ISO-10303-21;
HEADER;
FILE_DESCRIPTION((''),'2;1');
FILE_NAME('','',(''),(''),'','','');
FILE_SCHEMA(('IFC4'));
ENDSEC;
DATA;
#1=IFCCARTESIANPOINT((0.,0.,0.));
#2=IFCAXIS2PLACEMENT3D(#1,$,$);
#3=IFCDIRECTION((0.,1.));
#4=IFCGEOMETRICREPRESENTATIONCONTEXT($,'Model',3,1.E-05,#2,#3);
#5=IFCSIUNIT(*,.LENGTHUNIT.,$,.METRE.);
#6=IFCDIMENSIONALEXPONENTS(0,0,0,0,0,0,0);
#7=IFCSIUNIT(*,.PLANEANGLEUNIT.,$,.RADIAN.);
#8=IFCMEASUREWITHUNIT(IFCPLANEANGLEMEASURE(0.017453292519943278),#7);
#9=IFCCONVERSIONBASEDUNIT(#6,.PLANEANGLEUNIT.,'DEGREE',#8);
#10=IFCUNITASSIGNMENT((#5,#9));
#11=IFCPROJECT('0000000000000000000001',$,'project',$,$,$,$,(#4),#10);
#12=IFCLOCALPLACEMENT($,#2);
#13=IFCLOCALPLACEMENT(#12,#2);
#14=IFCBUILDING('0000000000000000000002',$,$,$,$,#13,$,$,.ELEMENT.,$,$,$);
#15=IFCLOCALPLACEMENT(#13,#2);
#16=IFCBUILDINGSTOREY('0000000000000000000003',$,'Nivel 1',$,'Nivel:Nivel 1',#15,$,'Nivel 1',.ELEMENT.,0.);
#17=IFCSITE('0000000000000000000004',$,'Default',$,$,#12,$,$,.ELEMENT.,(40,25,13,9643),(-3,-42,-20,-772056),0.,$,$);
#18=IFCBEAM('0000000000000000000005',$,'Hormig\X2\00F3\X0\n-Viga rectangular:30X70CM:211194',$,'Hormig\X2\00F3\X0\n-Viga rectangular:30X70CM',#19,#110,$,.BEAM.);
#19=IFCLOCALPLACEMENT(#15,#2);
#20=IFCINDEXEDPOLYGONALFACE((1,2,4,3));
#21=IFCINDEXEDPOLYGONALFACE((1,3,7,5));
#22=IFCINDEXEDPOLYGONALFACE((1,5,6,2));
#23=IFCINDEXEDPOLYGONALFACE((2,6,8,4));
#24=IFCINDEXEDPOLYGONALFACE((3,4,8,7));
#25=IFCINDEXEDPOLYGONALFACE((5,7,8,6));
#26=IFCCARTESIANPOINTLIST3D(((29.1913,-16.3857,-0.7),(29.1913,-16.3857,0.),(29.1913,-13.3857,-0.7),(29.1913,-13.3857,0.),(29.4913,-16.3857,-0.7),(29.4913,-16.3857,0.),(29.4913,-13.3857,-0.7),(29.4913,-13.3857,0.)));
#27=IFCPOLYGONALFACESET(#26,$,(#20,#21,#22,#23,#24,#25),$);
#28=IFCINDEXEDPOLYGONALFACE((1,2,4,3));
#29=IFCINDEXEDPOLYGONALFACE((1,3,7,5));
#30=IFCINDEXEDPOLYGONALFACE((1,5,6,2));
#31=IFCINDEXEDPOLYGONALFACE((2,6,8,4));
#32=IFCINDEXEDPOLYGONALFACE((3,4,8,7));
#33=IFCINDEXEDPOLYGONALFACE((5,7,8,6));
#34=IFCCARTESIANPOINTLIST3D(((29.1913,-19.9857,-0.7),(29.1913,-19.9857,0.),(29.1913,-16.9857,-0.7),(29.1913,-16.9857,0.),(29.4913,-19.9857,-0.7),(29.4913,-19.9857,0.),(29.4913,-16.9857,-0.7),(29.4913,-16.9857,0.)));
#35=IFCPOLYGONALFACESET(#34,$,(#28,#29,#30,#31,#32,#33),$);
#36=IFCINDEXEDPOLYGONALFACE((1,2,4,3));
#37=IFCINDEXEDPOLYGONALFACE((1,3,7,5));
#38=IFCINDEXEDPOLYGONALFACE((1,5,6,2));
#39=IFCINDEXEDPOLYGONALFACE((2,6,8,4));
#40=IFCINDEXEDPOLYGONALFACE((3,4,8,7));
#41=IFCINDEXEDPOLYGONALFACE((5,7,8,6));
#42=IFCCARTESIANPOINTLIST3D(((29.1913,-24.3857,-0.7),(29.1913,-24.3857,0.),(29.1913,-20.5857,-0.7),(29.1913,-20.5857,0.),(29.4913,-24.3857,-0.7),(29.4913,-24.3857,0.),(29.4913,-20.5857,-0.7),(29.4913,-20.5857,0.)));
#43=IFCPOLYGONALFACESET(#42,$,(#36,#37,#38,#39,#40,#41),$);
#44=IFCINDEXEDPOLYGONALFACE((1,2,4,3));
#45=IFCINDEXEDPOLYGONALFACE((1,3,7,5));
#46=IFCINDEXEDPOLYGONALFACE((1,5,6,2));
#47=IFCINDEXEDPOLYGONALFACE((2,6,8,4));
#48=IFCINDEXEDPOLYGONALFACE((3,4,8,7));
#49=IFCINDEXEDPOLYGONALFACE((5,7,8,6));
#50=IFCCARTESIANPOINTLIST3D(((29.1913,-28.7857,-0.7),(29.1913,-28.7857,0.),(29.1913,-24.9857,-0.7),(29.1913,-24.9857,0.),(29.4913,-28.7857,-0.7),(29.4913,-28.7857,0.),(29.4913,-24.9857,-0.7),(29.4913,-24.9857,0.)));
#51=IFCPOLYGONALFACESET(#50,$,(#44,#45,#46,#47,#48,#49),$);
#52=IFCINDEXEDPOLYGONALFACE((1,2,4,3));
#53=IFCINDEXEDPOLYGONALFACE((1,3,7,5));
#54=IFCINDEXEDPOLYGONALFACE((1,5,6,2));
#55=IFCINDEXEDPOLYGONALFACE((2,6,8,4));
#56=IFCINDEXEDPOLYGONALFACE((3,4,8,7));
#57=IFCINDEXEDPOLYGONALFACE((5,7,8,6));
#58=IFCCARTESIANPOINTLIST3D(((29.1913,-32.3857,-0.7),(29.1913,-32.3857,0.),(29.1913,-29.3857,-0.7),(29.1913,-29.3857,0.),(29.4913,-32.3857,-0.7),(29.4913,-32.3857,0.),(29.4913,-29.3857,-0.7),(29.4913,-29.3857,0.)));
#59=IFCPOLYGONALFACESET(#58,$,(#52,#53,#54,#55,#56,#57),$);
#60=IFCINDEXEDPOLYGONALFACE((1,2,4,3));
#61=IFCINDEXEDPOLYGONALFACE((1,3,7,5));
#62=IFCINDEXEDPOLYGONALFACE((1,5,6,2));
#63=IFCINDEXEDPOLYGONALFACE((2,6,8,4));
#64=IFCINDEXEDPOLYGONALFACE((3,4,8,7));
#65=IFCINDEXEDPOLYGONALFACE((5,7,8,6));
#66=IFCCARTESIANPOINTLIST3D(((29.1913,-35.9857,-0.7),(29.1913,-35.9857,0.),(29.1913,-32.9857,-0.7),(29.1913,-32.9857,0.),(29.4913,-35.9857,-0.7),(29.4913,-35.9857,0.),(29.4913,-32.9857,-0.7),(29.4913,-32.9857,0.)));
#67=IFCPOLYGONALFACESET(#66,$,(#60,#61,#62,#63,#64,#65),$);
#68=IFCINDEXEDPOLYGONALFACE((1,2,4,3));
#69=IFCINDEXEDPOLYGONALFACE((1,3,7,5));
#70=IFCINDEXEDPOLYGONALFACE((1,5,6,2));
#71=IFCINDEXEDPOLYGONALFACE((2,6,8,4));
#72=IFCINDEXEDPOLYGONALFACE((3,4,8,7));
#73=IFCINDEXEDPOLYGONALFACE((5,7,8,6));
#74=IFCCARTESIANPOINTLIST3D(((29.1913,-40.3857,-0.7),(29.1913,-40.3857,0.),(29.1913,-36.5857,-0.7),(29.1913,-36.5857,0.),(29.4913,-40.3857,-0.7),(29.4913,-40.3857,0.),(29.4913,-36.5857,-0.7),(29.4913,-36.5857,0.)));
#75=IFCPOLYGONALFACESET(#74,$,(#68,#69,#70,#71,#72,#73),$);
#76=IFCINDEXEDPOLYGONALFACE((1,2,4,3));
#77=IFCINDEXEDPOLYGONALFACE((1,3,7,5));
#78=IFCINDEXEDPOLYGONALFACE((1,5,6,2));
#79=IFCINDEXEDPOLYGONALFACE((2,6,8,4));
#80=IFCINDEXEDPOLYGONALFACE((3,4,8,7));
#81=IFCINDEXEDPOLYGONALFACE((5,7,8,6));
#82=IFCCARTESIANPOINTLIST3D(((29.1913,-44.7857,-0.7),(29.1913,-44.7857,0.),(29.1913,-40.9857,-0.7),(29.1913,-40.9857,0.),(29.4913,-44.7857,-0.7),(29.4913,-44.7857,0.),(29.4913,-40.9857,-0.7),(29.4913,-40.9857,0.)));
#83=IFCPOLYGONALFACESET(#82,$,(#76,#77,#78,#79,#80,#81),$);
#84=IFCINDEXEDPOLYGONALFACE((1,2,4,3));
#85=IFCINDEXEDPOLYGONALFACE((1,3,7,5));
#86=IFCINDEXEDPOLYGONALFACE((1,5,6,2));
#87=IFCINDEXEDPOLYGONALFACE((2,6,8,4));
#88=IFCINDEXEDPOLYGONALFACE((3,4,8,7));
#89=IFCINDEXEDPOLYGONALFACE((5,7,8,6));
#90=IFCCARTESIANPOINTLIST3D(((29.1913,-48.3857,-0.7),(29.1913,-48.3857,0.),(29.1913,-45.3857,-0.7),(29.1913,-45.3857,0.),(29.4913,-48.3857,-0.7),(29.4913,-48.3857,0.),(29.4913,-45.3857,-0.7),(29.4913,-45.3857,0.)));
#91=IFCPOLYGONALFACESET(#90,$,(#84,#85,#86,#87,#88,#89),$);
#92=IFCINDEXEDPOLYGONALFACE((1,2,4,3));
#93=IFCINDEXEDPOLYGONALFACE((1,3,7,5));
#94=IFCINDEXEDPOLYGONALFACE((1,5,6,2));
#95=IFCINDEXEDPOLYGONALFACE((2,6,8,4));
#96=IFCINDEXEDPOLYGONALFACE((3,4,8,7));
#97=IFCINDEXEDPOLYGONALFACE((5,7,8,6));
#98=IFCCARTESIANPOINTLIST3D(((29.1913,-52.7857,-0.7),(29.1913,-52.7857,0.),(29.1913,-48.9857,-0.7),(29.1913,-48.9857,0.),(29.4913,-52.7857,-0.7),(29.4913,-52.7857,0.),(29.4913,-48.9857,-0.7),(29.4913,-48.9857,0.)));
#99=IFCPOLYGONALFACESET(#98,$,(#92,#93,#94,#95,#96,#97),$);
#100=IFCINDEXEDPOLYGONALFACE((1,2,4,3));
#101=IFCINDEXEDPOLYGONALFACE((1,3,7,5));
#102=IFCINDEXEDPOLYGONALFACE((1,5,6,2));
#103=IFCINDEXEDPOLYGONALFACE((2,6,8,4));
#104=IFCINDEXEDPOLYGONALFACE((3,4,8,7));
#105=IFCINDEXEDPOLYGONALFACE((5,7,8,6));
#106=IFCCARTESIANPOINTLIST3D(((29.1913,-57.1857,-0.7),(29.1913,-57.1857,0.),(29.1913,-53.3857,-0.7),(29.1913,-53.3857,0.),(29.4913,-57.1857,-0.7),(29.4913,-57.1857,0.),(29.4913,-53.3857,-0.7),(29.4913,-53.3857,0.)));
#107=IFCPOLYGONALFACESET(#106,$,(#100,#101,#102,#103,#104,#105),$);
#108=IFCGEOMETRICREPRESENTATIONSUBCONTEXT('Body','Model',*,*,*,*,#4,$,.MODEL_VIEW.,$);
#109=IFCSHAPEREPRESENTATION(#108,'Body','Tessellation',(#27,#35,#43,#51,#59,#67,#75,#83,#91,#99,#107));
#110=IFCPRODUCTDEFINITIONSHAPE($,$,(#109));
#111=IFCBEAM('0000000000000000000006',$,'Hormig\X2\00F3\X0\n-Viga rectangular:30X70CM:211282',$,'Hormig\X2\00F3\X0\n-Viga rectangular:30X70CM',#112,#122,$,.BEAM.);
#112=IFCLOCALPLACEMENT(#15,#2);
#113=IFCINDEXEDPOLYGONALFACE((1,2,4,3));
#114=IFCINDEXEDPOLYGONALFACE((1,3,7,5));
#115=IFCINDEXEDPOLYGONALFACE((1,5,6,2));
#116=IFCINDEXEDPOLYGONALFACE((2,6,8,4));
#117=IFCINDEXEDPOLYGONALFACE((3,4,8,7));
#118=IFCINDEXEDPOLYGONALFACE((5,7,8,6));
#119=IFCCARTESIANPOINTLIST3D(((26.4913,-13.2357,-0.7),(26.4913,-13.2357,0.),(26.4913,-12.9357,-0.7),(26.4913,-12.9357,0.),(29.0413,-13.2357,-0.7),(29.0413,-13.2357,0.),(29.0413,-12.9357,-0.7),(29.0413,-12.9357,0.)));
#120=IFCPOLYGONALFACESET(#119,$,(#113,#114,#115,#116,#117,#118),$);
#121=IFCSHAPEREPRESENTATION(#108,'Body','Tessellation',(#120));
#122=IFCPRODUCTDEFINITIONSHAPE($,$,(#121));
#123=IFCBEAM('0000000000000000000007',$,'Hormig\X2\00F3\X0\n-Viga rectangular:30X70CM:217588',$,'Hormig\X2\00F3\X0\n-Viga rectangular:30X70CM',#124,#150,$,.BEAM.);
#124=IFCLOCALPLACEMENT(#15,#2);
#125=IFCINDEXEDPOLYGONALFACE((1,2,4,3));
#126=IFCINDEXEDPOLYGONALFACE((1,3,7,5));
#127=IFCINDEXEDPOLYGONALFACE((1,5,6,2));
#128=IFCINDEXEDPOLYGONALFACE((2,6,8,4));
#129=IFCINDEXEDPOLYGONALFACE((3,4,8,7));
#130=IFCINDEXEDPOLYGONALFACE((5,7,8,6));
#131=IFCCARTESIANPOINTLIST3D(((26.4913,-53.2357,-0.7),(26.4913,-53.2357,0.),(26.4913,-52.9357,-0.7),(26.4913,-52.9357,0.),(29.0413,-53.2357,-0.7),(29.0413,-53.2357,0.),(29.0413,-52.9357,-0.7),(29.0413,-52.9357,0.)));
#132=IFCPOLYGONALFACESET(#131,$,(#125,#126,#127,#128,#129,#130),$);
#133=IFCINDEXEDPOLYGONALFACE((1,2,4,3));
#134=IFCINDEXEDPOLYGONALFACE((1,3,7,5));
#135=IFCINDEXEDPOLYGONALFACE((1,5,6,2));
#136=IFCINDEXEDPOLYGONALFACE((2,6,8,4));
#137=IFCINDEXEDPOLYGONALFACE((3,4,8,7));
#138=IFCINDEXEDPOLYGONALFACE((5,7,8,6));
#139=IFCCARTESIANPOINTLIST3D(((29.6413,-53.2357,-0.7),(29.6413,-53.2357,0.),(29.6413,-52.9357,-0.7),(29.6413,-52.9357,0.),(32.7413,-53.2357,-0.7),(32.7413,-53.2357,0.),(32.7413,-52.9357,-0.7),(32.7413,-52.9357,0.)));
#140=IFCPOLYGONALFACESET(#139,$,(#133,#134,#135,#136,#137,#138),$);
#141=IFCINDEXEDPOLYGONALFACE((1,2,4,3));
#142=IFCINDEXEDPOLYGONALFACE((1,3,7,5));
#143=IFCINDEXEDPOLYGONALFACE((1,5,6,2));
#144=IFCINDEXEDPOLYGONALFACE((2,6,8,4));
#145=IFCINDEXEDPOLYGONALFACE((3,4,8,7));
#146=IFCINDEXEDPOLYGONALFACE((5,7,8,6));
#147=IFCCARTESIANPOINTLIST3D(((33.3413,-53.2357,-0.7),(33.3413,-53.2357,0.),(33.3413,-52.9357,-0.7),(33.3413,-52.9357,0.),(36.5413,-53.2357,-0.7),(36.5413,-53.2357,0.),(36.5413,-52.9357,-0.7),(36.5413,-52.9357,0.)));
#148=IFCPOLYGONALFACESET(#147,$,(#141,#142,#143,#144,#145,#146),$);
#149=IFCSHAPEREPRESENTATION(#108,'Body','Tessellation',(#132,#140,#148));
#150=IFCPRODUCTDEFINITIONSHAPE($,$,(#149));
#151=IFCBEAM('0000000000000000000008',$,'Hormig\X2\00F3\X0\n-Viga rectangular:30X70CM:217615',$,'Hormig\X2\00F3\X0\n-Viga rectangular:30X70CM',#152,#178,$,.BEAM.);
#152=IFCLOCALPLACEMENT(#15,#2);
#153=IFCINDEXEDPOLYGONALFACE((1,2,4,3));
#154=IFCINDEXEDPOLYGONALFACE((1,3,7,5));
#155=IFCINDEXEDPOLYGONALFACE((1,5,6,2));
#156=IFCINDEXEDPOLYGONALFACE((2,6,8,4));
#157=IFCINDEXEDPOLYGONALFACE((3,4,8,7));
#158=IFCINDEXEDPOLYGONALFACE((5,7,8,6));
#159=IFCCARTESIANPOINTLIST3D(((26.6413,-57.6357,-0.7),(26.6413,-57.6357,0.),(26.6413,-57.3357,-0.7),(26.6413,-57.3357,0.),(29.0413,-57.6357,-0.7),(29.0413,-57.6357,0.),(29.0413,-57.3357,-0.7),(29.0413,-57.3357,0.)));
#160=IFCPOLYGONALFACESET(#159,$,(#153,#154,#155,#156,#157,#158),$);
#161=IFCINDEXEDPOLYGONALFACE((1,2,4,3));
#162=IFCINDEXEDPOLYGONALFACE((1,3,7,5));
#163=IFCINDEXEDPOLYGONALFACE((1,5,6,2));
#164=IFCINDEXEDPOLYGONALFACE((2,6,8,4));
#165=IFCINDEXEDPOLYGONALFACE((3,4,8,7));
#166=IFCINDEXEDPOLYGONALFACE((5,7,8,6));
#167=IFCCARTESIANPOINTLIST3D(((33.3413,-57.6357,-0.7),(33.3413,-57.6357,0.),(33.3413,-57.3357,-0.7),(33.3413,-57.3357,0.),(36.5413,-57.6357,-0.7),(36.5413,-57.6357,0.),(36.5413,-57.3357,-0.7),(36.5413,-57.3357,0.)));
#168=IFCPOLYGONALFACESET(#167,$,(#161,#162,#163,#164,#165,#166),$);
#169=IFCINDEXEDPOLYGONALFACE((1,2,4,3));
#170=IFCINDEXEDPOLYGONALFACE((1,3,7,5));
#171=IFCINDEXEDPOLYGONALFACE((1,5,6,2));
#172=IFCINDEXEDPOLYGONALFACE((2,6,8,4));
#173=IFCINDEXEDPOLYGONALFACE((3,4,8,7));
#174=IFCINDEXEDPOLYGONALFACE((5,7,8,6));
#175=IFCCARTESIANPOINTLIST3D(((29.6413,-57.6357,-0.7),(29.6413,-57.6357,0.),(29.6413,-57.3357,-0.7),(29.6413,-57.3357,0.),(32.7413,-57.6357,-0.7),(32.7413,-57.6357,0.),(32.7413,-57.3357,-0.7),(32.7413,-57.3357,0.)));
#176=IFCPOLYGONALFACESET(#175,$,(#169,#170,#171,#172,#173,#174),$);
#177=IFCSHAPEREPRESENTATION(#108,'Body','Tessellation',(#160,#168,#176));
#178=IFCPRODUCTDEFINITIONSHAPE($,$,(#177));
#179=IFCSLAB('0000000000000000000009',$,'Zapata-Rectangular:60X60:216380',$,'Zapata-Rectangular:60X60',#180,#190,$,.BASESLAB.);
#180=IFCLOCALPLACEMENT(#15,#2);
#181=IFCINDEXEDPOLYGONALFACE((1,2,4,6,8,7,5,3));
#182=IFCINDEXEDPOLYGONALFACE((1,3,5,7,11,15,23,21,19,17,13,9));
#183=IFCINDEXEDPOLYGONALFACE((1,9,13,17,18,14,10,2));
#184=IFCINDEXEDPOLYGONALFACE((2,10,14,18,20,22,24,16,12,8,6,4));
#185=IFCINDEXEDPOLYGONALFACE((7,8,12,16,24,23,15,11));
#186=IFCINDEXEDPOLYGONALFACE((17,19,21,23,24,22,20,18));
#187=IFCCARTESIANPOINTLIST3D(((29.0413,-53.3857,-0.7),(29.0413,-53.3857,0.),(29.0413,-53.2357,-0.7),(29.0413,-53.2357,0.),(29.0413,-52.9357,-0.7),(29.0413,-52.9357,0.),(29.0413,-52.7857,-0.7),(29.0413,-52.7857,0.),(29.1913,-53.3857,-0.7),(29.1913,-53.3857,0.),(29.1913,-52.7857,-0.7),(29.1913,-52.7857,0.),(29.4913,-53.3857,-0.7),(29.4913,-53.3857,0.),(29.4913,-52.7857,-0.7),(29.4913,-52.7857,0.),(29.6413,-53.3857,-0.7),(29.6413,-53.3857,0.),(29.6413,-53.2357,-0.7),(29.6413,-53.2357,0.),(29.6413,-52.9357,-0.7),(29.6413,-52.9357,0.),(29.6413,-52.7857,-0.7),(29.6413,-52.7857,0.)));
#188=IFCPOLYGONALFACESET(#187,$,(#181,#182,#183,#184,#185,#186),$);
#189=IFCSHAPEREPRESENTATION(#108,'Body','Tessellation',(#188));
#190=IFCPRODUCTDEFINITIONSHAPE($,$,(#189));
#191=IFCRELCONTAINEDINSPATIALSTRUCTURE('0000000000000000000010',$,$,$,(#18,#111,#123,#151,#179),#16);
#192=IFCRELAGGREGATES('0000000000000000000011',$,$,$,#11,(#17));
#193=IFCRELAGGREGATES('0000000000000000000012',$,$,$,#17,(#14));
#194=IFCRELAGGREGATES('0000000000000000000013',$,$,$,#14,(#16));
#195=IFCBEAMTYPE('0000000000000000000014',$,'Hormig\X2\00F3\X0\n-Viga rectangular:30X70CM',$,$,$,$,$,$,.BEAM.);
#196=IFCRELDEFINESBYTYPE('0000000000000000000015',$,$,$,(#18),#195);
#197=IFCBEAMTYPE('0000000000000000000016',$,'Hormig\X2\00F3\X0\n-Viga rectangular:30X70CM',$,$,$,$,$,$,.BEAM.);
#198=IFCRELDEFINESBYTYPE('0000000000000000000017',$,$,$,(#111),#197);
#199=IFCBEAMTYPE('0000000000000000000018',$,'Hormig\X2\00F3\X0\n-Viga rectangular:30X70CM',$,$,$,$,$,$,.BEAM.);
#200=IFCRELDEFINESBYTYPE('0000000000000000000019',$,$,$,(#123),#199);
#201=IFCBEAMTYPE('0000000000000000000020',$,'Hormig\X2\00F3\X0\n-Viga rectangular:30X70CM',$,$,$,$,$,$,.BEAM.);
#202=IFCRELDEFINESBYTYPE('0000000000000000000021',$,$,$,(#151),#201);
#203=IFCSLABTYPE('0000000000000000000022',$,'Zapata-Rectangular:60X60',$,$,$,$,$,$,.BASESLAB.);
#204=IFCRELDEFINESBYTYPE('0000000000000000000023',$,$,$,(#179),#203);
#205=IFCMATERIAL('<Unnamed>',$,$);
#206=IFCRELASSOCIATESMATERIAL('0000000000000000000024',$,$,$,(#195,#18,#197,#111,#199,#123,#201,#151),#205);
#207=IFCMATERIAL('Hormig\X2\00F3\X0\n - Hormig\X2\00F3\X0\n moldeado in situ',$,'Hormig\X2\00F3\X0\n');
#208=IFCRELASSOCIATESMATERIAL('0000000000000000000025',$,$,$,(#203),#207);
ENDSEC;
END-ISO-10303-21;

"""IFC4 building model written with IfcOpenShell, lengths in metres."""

from ifc_helpers import new_model, entity, si_unit, converted_unit, direction, frame, origin, place, context, subcontext, project, spatial, indexed_curve, outline, extrude, source, transform, mapped, material, type_object, type_shapes, element, save


model = new_model("IFC4")

# Units and contexts
model_context = context("Model", 3, precision=1e-05, world=origin(), true_north=direction((0.0, 1.0)))
body_context = subcontext(model_context, "Body", "Model", "MODEL_VIEW")
ifc_project = project(units=[si_unit("LENGTHUNIT", "METRE"), converted_unit("PLANEANGLEUNIT", "DEGREE", entity("IfcPlaneAngleMeasure", 0.017453292519943278), si_unit("PLANEANGLEUNIT", "RADIAN"), dimensions=[0, 0, 0, 0, 0, 0, 0])], contexts=[model_context])

# Site, building, storey
site_placement = place(None, origin())
site = spatial("IfcSite", under=ifc_project, at=site_placement, Name="Default", CompositionType="ELEMENT", RefLatitude=(40, 25, 13, 9643), RefLongitude=(-3, -42, -20, -772056), RefElevation=0.0)
building_placement = place(site_placement, origin())
building = spatial("IfcBuilding", under=site, at=building_placement, CompositionType="ELEMENT")
storey_placement = place(building_placement, origin())
storey = spatial("IfcBuildingStorey", under=building, at=storey_placement, Name="Nivel 1", ObjectType="Nivel:Nivel 1", LongName="Nivel 1", CompositionType="ELEMENT", Elevation=0.0)

# Beams
ifc_material_1 = material(Name="<Unnamed>")
beam_type_1 = type_object("IfcBeamType", Name="Hormigón-Viga rectangular:30X70CM", PredefinedType="BEAM", material=ifc_material_1)
shared_shape_1 = source(origin(), body_context, "Body", "SweptSolid", [
    extrude(outline(indexed_curve([(-0.15, -0.35), (0.15, -0.35), (0.15, 0.35), (-0.15, 0.35), (-0.15, -0.35)], self_intersect=False)), frame((29.3413, -13.3857, -0.35), z_axis=(0.0, -1.0, 0.0), x_axis=(-1.0, 0.0, 0.0)), (0.0, 0.0, 1.0), 3.0),
    extrude(outline(indexed_curve([(-0.15, -0.35), (0.15, -0.35), (0.15, 0.35), (-0.15, 0.35), (-0.15, -0.35)], self_intersect=False)), frame((29.3413, -16.9857, -0.35), z_axis=(0.0, -1.0, 0.0), x_axis=(-1.0, 0.0, 0.0)), (0.0, 0.0, 1.0), 3.0),
    extrude(outline(indexed_curve([(-0.15, -0.35), (0.15, -0.35), (0.15, 0.35), (-0.15, 0.35), (-0.15, -0.35)], self_intersect=False)), frame((29.3413, -20.5857, -0.35), z_axis=(0.0, -1.0, 0.0), x_axis=(-1.0, 0.0, 0.0)), (0.0, 0.0, 1.0), 3.8),
    extrude(outline(indexed_curve([(-0.15, -0.35), (0.15, -0.35), (0.15, 0.35), (-0.15, 0.35), (-0.15, -0.35)], self_intersect=False)), frame((29.3413, -24.9857, -0.35), z_axis=(0.0, -1.0, 0.0), x_axis=(-1.0, 0.0, 0.0)), (0.0, 0.0, 1.0), 3.8),
    extrude(outline(indexed_curve([(-0.15, -0.35), (0.15, -0.35), (0.15, 0.35), (-0.15, 0.35), (-0.15, -0.35)], self_intersect=False)), frame((29.3413, -29.3857, -0.35), z_axis=(0.0, -1.0, 0.0), x_axis=(-1.0, 0.0, 0.0)), (0.0, 0.0, 1.0), 3.0),
    extrude(outline(indexed_curve([(-0.15, -0.35), (0.15, -0.35), (0.15, 0.35), (-0.15, 0.35), (-0.15, -0.35)], self_intersect=False)), frame((29.3413, -32.9857, -0.35), z_axis=(0.0, -1.0, 0.0), x_axis=(-1.0, 0.0, 0.0)), (0.0, 0.0, 1.0), 3.0),
    extrude(outline(indexed_curve([(-0.15, -0.35), (0.15, -0.35), (0.15, 0.35), (-0.15, 0.35), (-0.15, -0.35)], self_intersect=False)), frame((29.3413, -36.5857, -0.35), z_axis=(0.0, -1.0, 0.0), x_axis=(-1.0, 0.0, 0.0)), (0.0, 0.0, 1.0), 3.8),
    extrude(outline(indexed_curve([(-0.15, -0.35), (0.15, -0.35), (0.15, 0.35), (-0.15, 0.35), (-0.15, -0.35)], self_intersect=False)), frame((29.3413, -40.9857, -0.35), z_axis=(0.0, -1.0, 0.0), x_axis=(-1.0, 0.0, 0.0)), (0.0, 0.0, 1.0), 3.8),
    extrude(outline(indexed_curve([(-0.15, -0.35), (0.15, -0.35), (0.15, 0.35), (-0.15, 0.35), (-0.15, -0.35)], self_intersect=False)), frame((29.3413, -45.3857, -0.35), z_axis=(0.0, -1.0, 0.0), x_axis=(-1.0, 0.0, 0.0)), (0.0, 0.0, 1.0), 3.0),
    extrude(outline(indexed_curve([(-0.15, -0.35), (0.15, -0.35), (0.15, 0.35), (-0.15, 0.35), (-0.15, -0.35)], self_intersect=False)), frame((29.3413, -48.9857, -0.35), z_axis=(0.0, -1.0, 0.0), x_axis=(-1.0, 0.0, 0.0)), (0.0, 0.0, 1.0), 3.8),
    extrude(outline(indexed_curve([(-0.15, -0.35), (0.15, -0.35), (0.15, 0.35), (-0.15, 0.35), (-0.15, -0.35)], self_intersect=False)), frame((29.3413, -53.3857, -0.35), z_axis=(0.0, -1.0, 0.0), x_axis=(-1.0, 0.0, 0.0)), (0.0, 0.0, 1.0), 3.8),
])
type_shapes(beam_type_1, [shared_shape_1])
beam_1_placement = place(storey_placement, origin())
element("IfcBeam", 1, at=beam_1_placement, inside=storey, type_object=beam_type_1, material=ifc_material_1, Name="Hormigón-Viga rectangular:30X70CM:211194", ObjectType="Hormigón-Viga rectangular:30X70CM", PredefinedType="BEAM", context=body_context, shape_type="MappedRepresentation", body=[
    mapped(shared_shape_1, transform((0.0, 0.0, 0.0), scale=1.0)),
])
beam_type_2 = type_object("IfcBeamType", Name="Hormigón-Viga rectangular:30X70CM", PredefinedType="BEAM", material=ifc_material_1)
shared_shape_2 = source(origin(), body_context, "Body", "SweptSolid", [
    extrude(outline(indexed_curve([(-0.35, -0.15), (0.35, -0.15), (0.35, 0.15), (-0.35, 0.15), (-0.35, -0.15)], self_intersect=False)), frame((29.0413, -13.0857, -0.35), z_axis=(-1.0, 0.0, 0.0), x_axis=(0.0, 0.0, -1.0)), (0.0, 0.0, 1.0), 2.55),
])
type_shapes(beam_type_2, [shared_shape_2])
beam_2_placement = place(storey_placement, origin())
element("IfcBeam", 2, at=beam_2_placement, inside=storey, type_object=beam_type_2, material=ifc_material_1, Name="Hormigón-Viga rectangular:30X70CM:211282", ObjectType="Hormigón-Viga rectangular:30X70CM", PredefinedType="BEAM", context=body_context, shape_type="MappedRepresentation", body=[
    mapped(shared_shape_2, transform((0.0, 0.0, 0.0), scale=1.0)),
])
beam_type_3 = type_object("IfcBeamType", Name="Hormigón-Viga rectangular:30X70CM", PredefinedType="BEAM", material=ifc_material_1)
shared_shape_3 = source(origin(), body_context, "Body", "SweptSolid", [
    extrude(outline(indexed_curve([(-0.35, -0.15), (0.35, -0.15), (0.35, 0.15), (-0.35, 0.15), (-0.35, -0.15)], self_intersect=False)), frame((26.4913, -53.0857, -0.35), z_axis=(1.0, 0.0, 0.0), x_axis=(0.0, 0.0, -1.0)), (0.0, 0.0, 1.0), 2.55),
    extrude(outline(indexed_curve([(-0.35, -0.15), (0.35, -0.15), (0.35, 0.15), (-0.35, 0.15), (-0.35, -0.15)], self_intersect=False)), frame((29.6413, -53.0857, -0.35), z_axis=(1.0, 0.0, 0.0), x_axis=(0.0, 0.0, -1.0)), (0.0, 0.0, 1.0), 3.1),
    extrude(outline(indexed_curve([(-0.35, -0.15), (0.35, -0.15), (0.35, 0.15), (-0.35, 0.15), (-0.35, -0.15)], self_intersect=False)), frame((33.3413, -53.0857, -0.35), z_axis=(1.0, 0.0, 0.0), x_axis=(0.0, 0.0, -1.0)), (0.0, 0.0, 1.0), 3.2),
])
type_shapes(beam_type_3, [shared_shape_3])
beam_3_placement = place(storey_placement, origin())
element("IfcBeam", 3, at=beam_3_placement, inside=storey, type_object=beam_type_3, material=ifc_material_1, Name="Hormigón-Viga rectangular:30X70CM:217588", ObjectType="Hormigón-Viga rectangular:30X70CM", PredefinedType="BEAM", context=body_context, shape_type="MappedRepresentation", body=[
    mapped(shared_shape_3, transform((0.0, 0.0, 0.0), scale=1.0)),
])
beam_type_4 = type_object("IfcBeamType", Name="Hormigón-Viga rectangular:30X70CM", PredefinedType="BEAM", material=ifc_material_1)
shared_shape_4 = source(origin(), body_context, "Body", "SweptSolid", [
    extrude(outline(indexed_curve([(-0.35, -0.15), (0.35, -0.15), (0.35, 0.15), (-0.35, 0.15), (-0.35, -0.15)], self_intersect=False)), frame((26.6413, -57.4857, -0.35), z_axis=(1.0, 0.0, 0.0), x_axis=(0.0, 0.0, -1.0)), (0.0, 0.0, 1.0), 2.4),
    extrude(outline(indexed_curve([(-0.35, -0.15), (0.35, -0.15), (0.35, 0.15), (-0.35, 0.15), (-0.35, -0.15)], self_intersect=False)), frame((33.3413, -57.4857, -0.35), z_axis=(1.0, 0.0, 0.0), x_axis=(0.0, 0.0, -1.0)), (0.0, 0.0, 1.0), 3.2),
    extrude(outline(indexed_curve([(-0.35, -0.15), (0.35, -0.15), (0.35, 0.15), (-0.35, 0.15), (-0.35, -0.15)], self_intersect=False)), frame((29.6413, -57.4857, -0.35), z_axis=(1.0, 0.0, 0.0), x_axis=(0.0, 0.0, -1.0)), (0.0, 0.0, 1.0), 3.1),
])
type_shapes(beam_type_4, [shared_shape_4])
beam_4_placement = place(storey_placement, origin())
element("IfcBeam", 4, at=beam_4_placement, inside=storey, type_object=beam_type_4, material=ifc_material_1, Name="Hormigón-Viga rectangular:30X70CM:217615", ObjectType="Hormigón-Viga rectangular:30X70CM", PredefinedType="BEAM", context=body_context, shape_type="MappedRepresentation", body=[
    mapped(shared_shape_4, transform((0.0, 0.0, 0.0), scale=1.0)),
])

# Slab
ifc_material_2 = material(Name="Hormigón - Hormigón moldeado in situ", Category="Hormigón")
slab_type_1 = type_object("IfcSlabType", Name="Zapata-Rectangular:60X60", PredefinedType="BASESLAB", material=ifc_material_2)
slab_1_placement = place(storey_placement, origin())
element("IfcSlab", 5, at=slab_1_placement, inside=storey, type_object=slab_type_1, Name="Zapata-Rectangular:60X60:216380", ObjectType="Zapata-Rectangular:60X60", PredefinedType="BASESLAB", context=body_context, shape_type="SweptSolid", body=[
    extrude(outline(indexed_curve([(-0.3, -0.3), (-0.15, -0.3), (0.15, -0.3), (0.3, -0.3), (0.3, -0.15), (0.3, 0.15), (0.3, 0.3), (0.15, 0.3), (-0.15, 0.3), (-0.3, 0.3), (-0.3, 0.15), (-0.3, -0.15), (-0.3, -0.3)], self_intersect=False)), frame((29.3413, -53.0857, -0.7), z_axis=(0.0, 0.0, 1.0), x_axis=(-1.0, 0.0, 0.0)), (0.0, 0.0, 1.0), 0.7),
])

save(model, "model.ifc")
